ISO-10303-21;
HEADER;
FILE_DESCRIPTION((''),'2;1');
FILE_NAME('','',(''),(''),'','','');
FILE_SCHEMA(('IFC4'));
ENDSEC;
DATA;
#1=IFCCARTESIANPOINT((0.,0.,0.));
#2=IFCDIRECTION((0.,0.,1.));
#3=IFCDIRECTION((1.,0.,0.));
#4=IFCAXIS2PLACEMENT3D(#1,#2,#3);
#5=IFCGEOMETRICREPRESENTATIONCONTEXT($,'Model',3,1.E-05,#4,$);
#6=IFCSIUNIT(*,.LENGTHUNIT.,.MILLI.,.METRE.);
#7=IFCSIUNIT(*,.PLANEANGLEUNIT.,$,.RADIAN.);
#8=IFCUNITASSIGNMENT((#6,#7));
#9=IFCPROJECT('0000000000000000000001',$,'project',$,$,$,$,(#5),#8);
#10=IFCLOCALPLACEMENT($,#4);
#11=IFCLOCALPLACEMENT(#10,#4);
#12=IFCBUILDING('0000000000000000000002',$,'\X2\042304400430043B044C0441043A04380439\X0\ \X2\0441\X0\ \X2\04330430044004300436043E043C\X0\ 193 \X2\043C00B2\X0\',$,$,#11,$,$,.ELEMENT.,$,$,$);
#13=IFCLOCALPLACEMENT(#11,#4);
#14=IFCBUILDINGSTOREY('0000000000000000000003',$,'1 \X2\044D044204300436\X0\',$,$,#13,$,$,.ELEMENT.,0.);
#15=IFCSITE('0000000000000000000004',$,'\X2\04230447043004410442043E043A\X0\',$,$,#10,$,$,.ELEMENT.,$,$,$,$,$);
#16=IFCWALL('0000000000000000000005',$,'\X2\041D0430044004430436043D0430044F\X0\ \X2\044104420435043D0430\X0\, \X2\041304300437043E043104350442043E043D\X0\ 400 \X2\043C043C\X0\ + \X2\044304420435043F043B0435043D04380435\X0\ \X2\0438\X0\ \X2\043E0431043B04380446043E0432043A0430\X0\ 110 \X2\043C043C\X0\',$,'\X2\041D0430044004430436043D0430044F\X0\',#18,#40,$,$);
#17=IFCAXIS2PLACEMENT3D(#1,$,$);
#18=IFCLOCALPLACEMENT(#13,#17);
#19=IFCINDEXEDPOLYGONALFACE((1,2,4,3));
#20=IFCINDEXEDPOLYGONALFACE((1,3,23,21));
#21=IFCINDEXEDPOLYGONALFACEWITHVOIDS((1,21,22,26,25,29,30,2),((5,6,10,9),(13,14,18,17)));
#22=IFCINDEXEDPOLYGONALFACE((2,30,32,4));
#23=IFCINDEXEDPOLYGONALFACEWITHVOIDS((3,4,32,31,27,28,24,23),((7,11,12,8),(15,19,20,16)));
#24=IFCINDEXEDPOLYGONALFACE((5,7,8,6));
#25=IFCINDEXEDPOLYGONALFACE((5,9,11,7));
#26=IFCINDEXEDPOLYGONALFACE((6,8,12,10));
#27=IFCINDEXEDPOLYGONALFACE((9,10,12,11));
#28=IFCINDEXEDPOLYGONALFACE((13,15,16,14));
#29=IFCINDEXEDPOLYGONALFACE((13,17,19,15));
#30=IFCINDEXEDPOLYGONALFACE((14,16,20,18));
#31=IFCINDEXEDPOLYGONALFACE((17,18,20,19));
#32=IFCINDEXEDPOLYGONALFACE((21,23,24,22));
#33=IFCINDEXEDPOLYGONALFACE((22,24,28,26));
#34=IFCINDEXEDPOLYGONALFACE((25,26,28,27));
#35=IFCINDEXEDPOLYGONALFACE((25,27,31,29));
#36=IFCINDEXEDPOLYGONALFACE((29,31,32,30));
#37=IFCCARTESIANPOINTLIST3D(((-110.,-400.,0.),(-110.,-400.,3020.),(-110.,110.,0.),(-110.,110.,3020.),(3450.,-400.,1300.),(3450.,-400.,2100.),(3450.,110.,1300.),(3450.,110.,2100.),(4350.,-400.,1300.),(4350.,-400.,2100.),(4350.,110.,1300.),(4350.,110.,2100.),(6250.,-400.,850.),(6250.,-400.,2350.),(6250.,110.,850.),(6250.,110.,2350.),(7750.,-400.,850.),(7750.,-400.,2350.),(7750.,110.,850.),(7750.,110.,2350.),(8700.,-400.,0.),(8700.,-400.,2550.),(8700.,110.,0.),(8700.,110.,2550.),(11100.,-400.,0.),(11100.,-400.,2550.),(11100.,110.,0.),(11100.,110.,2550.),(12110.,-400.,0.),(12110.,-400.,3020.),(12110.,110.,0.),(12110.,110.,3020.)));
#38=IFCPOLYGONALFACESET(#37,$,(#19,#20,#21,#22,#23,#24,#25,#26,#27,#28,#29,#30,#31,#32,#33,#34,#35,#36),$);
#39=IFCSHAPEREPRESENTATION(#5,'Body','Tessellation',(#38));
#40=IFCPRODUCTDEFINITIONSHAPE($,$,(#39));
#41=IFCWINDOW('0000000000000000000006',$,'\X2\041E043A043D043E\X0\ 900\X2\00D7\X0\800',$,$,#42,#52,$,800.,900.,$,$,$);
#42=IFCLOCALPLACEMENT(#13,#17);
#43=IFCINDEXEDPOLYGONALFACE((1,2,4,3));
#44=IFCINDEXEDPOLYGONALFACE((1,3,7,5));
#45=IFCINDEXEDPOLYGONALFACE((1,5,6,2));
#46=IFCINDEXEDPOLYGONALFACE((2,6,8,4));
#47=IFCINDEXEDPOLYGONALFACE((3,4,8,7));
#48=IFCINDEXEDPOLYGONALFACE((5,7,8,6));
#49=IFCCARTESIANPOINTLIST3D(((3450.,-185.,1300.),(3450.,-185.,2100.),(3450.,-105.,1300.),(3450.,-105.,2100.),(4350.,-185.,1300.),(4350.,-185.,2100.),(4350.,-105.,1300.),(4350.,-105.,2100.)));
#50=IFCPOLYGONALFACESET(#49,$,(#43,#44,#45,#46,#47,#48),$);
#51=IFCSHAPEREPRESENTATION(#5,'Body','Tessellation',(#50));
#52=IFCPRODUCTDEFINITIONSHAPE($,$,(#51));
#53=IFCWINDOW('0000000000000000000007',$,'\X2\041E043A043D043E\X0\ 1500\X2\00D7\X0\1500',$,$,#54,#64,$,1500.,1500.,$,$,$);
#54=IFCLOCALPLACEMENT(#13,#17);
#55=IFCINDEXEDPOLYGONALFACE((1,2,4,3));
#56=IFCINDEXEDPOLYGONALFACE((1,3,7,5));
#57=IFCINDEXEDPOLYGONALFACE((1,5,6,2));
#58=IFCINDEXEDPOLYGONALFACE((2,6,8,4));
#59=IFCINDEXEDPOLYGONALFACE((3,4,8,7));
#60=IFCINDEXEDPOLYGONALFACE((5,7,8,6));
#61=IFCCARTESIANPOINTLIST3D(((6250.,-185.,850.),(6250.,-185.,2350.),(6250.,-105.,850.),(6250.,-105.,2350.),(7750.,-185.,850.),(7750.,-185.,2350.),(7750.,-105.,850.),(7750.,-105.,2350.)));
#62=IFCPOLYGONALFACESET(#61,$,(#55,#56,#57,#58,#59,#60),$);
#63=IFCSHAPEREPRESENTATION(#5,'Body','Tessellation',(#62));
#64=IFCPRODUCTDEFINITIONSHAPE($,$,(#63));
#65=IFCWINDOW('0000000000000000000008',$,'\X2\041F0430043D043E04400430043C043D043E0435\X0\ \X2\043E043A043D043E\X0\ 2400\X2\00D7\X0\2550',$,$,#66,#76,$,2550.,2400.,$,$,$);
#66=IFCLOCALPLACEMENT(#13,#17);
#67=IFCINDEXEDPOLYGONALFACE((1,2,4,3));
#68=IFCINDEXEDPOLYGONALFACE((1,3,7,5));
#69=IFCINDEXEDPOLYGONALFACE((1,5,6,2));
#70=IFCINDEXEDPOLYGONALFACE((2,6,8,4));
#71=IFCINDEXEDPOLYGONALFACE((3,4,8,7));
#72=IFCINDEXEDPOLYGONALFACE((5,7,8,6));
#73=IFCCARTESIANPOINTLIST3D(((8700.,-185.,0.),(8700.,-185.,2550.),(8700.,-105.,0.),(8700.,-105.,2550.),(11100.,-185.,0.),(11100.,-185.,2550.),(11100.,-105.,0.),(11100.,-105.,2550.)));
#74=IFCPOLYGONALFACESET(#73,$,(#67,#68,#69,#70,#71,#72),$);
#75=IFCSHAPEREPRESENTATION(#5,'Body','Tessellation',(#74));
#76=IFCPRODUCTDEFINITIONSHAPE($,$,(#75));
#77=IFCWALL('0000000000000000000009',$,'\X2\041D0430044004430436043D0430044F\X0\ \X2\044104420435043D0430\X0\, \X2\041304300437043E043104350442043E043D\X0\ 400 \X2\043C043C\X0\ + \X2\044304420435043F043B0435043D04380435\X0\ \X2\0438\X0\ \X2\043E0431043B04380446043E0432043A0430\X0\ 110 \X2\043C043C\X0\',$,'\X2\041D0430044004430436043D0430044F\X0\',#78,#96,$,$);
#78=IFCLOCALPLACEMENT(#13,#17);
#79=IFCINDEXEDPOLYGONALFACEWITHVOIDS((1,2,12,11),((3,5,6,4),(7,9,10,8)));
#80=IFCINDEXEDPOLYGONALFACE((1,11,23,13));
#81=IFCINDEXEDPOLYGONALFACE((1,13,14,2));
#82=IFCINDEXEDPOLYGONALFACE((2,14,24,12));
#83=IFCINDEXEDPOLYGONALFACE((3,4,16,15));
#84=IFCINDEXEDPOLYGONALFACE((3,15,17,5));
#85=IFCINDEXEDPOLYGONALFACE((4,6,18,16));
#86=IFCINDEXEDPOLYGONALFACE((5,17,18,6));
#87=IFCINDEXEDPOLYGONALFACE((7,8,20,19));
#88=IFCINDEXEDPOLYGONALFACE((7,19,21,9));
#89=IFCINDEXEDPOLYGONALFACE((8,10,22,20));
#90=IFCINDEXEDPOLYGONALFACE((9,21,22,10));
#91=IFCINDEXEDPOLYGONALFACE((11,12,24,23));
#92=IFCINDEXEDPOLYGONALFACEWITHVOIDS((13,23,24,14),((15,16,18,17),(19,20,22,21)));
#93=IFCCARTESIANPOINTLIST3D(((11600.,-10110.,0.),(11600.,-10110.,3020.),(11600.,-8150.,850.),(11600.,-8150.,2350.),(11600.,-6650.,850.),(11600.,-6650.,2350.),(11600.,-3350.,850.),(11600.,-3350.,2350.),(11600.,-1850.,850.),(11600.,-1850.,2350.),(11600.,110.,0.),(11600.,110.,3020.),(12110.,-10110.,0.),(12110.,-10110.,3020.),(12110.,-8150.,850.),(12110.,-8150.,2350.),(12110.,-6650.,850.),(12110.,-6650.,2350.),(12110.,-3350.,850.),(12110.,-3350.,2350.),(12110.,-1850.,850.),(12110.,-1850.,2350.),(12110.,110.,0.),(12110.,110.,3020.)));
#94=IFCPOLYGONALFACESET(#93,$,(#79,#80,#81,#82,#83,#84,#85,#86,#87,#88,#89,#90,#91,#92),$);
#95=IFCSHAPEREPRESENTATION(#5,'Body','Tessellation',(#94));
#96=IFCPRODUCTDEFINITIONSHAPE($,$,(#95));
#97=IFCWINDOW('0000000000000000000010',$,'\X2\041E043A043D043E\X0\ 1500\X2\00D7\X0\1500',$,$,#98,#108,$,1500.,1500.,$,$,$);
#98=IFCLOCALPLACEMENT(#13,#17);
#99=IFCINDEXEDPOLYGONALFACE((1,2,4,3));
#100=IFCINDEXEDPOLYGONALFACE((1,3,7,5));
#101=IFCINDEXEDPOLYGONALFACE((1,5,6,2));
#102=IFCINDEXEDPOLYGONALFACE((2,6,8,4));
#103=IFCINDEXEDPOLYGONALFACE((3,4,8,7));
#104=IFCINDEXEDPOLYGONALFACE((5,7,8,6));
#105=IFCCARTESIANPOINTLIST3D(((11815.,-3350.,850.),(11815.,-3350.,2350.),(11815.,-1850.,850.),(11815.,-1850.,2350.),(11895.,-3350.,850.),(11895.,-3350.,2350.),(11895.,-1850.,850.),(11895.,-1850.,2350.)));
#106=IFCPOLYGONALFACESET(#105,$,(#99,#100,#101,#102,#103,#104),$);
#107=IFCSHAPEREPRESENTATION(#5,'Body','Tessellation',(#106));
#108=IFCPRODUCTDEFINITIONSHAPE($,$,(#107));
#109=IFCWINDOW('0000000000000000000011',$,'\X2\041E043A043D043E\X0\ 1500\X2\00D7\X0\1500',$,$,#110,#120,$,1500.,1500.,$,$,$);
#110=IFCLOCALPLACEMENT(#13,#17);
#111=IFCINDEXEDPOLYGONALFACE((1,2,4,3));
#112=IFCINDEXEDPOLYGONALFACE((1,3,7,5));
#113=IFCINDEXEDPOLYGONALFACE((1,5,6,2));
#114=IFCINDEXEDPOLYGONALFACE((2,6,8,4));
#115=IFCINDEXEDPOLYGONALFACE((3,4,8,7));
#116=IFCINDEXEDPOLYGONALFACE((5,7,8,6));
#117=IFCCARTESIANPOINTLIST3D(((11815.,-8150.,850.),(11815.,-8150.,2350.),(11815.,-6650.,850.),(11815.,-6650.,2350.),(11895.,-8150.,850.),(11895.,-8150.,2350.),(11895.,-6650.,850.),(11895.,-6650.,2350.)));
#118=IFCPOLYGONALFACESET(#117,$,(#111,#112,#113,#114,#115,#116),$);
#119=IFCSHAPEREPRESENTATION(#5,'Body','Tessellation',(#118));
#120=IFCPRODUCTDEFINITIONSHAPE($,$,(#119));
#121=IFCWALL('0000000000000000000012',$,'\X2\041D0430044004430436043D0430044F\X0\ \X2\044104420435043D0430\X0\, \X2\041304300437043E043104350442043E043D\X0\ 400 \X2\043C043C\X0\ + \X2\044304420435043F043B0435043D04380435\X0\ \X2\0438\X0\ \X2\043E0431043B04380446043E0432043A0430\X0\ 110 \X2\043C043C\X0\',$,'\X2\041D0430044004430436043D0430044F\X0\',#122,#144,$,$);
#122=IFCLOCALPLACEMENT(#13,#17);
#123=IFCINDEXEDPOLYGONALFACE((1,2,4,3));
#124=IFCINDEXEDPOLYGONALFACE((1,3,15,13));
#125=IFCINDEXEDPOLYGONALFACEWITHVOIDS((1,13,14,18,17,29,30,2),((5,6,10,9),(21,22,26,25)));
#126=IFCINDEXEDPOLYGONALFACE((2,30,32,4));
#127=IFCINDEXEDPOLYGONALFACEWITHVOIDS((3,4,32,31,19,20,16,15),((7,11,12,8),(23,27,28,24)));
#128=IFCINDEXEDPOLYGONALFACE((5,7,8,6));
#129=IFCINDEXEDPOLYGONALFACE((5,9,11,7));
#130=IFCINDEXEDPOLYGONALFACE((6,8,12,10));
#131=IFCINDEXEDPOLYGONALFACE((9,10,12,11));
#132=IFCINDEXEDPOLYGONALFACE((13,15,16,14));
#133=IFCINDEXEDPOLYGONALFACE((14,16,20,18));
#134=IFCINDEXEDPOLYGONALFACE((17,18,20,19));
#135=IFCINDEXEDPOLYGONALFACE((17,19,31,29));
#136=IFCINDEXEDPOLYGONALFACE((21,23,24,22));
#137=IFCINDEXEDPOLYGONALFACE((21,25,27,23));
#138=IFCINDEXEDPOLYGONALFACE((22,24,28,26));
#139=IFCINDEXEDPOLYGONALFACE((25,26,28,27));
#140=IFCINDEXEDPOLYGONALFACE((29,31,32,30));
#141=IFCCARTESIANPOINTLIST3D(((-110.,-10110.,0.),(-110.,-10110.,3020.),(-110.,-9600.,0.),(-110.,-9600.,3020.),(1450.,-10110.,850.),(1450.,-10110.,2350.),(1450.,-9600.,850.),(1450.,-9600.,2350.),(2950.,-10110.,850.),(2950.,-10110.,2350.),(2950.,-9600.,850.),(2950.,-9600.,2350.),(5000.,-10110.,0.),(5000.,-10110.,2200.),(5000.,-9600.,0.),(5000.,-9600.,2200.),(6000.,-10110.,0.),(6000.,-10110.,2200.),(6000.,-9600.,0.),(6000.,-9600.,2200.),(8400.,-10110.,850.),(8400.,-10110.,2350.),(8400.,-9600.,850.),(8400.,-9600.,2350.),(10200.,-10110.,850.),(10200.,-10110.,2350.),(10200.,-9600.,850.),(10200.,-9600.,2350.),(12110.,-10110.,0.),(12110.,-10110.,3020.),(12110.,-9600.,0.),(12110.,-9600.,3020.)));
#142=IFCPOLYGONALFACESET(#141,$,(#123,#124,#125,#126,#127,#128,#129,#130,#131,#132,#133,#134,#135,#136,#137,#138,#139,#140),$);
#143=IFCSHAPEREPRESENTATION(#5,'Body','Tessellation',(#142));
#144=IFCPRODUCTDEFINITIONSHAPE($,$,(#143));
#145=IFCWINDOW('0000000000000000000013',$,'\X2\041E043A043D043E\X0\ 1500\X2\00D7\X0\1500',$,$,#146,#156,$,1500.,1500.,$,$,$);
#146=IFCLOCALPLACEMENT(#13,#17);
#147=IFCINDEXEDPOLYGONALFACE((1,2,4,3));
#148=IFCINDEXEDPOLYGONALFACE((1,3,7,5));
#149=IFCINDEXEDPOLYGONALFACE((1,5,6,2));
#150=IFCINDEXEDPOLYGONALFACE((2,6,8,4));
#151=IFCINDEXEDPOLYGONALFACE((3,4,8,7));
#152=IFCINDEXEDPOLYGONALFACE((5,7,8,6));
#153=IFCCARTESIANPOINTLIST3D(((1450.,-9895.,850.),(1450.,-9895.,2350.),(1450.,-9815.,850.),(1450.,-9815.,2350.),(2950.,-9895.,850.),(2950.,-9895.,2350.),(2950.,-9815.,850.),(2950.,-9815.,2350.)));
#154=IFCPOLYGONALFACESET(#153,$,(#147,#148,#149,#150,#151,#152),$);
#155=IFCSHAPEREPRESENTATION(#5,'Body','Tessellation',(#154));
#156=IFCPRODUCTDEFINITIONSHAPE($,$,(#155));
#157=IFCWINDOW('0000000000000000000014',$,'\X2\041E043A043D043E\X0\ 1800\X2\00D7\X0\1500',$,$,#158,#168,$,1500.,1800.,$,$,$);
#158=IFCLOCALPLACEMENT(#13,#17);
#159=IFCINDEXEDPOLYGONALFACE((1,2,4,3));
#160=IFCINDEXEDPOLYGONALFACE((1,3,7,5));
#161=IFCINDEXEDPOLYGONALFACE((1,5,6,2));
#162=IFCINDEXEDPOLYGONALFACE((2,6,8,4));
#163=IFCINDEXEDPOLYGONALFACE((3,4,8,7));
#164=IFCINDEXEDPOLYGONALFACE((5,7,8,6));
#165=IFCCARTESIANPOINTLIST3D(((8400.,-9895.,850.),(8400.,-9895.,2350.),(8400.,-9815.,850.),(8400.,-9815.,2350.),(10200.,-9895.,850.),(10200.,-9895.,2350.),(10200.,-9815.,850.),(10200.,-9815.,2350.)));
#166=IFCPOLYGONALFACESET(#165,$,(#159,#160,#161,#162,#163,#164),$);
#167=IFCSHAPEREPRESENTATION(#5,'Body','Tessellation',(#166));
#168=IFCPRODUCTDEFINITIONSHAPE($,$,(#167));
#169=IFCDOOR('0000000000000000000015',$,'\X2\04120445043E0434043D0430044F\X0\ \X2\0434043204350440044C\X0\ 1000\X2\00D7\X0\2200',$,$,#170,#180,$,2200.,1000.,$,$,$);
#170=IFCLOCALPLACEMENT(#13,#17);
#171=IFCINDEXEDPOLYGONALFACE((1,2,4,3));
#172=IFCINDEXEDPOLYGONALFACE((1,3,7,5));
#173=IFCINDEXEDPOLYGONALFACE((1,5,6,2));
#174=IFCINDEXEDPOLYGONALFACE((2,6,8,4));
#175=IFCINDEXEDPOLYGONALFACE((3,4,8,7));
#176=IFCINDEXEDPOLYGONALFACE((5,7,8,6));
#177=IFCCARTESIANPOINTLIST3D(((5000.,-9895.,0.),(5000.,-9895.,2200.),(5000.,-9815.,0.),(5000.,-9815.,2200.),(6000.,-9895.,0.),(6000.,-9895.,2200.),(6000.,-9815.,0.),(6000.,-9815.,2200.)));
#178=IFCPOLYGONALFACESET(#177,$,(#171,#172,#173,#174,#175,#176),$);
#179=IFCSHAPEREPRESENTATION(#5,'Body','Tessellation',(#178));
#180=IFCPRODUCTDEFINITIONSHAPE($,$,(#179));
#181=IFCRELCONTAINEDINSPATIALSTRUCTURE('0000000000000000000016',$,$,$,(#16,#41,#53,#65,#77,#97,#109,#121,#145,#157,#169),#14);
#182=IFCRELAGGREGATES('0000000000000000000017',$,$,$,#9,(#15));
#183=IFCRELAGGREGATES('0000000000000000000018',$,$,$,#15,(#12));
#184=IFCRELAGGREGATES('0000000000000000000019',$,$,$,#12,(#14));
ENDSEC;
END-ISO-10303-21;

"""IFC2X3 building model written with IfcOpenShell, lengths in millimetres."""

from ifc_helpers import new_model, si_unit, frame, frame_2d, origin, origin_with_axes, place, context, project, spatial, rectangle, extrude, element, fill, save


model = new_model("IFC2X3")

# Units and contexts
model_context = context("Model", 3, precision=1e-05, world=origin_with_axes())
ifc_project = project(units=[si_unit("LENGTHUNIT", "METRE", prefix="MILLI"), si_unit("PLANEANGLEUNIT", "RADIAN")], contexts=[model_context])

# Site, building, storey
site_placement = place(None, origin_with_axes())
site = spatial("IfcSite", under=ifc_project, at=site_placement, Name="Участок", CompositionType="ELEMENT")
building_placement = place(site_placement, origin_with_axes())
building = spatial("IfcBuilding", under=site, at=building_placement, Name="Уральский с гаражом 193 м²", CompositionType="ELEMENT")
storey_placement = place(building_placement, origin_with_axes())
storey = spatial("IfcBuildingStorey", under=building, at=storey_placement, Name="1 этаж", CompositionType="ELEMENT", Elevation=0.0)

# Walls, openings, windows
wall_1_placement = place(storey_placement, origin_with_axes())
wall_1 = element("IfcWall", 1, at=wall_1_placement, inside=storey, Name="Наружная стена, Газобетон 400 мм + утепление и облицовка 110 мм", ObjectType="Наружная", context=model_context, shape_type="SweptSolid", body=[
    extrude(rectangle(XDim=12220.0, YDim=510.0, at=frame_2d((6000.0, -145.0))), origin(), (0.0, 0.0, 1.0), 3020.0),
])
opening_1_placement = place(storey_placement, origin_with_axes())
opening_1 = element("IfcOpeningElement", 2, at=opening_1_placement, cuts=wall_1, ObjectType="Opening", context=model_context, shape_type="SweptSolid", body=[
    extrude(rectangle(XDim=900.0, YDim=530.0, at=frame_2d((3900.0, -145.0))), frame((0.0, 0.0, 1300.0)), (0.0, 0.0, 1.0), 800.0),
])
opening_2_placement = place(storey_placement, origin_with_axes())
opening_2 = element("IfcOpeningElement", 3, at=opening_2_placement, cuts=wall_1, ObjectType="Opening", context=model_context, shape_type="SweptSolid", body=[
    extrude(rectangle(XDim=1500.0, YDim=530.0, at=frame_2d((7000.0, -145.0))), frame((0.0, 0.0, 850.0)), (0.0, 0.0, 1.0), 1500.0),
])
opening_3_placement = place(storey_placement, origin_with_axes())
opening_3 = element("IfcOpeningElement", 4, at=opening_3_placement, cuts=wall_1, ObjectType="Opening", context=model_context, shape_type="SweptSolid", body=[
    extrude(rectangle(XDim=2400.0, YDim=530.0, at=frame_2d((9900.0, -145.0))), origin(), (0.0, 0.0, 1.0), 2550.0),
])
window_1_placement = place(storey_placement, origin_with_axes())
window_1 = element("IfcWindow", 5, at=window_1_placement, inside=storey, Name="Окно 900×800", OverallHeight=800.0, OverallWidth=900.0, context=model_context, shape_type="SweptSolid", body=[
    extrude(rectangle(XDim=900.0, YDim=80.0, at=frame_2d((3900.0, -145.0))), frame((0.0, 0.0, 1300.0)), (0.0, 0.0, 1.0), 800.0),
])
fill(opening_1, window_1)
window_2_placement = place(storey_placement, origin_with_axes())
window_2 = element("IfcWindow", 6, at=window_2_placement, inside=storey, Name="Окно 1500×1500", OverallHeight=1500.0, OverallWidth=1500.0, context=model_context, shape_type="SweptSolid", body=[
    extrude(rectangle(XDim=1500.0, YDim=80.0, at=frame_2d((7000.0, -145.0))), frame((0.0, 0.0, 850.0)), (0.0, 0.0, 1.0), 1500.0),
])
fill(opening_2, window_2)
window_3_placement = place(storey_placement, origin_with_axes())
window_3 = element("IfcWindow", 7, at=window_3_placement, inside=storey, Name="Панорамное окно 2400×2550", OverallHeight=2550.0, OverallWidth=2400.0, context=model_context, shape_type="SweptSolid", body=[
    extrude(rectangle(XDim=2400.0, YDim=80.0, at=frame_2d((9900.0, -145.0))), origin(), (0.0, 0.0, 1.0), 2550.0),
])
fill(opening_3, window_3)
wall_2_placement = place(storey_placement, origin_with_axes())
wall_2 = element("IfcWall", 8, at=wall_2_placement, inside=storey, Name="Наружная стена, Газобетон 400 мм + утепление и облицовка 110 мм", ObjectType="Наружная", context=model_context, shape_type="SweptSolid", body=[
    extrude(rectangle(XDim=510.0, YDim=10220.0, at=frame_2d((11855.0, -5000.0))), origin(), (0.0, 0.0, 1.0), 3020.0),
])
opening_4_placement = place(storey_placement, origin_with_axes())
opening_4 = element("IfcOpeningElement", 9, at=opening_4_placement, cuts=wall_2, ObjectType="Opening", context=model_context, shape_type="SweptSolid", body=[
    extrude(rectangle(XDim=530.0, YDim=1500.0, at=frame_2d((11855.0, -2600.0))), frame((0.0, 0.0, 850.0)), (0.0, 0.0, 1.0), 1500.0),
])
opening_5_placement = place(storey_placement, origin_with_axes())
opening_5 = element("IfcOpeningElement", 10, at=opening_5_placement, cuts=wall_2, ObjectType="Opening", context=model_context, shape_type="SweptSolid", body=[
    extrude(rectangle(XDim=530.0, YDim=1500.0, at=frame_2d((11855.0, -7400.0))), frame((0.0, 0.0, 850.0)), (0.0, 0.0, 1.0), 1500.0),
])
window_4_placement = place(storey_placement, origin_with_axes())
window_4 = element("IfcWindow", 11, at=window_4_placement, inside=storey, Name="Окно 1500×1500", OverallHeight=1500.0, OverallWidth=1500.0, context=model_context, shape_type="SweptSolid", body=[
    extrude(rectangle(XDim=80.0, YDim=1500.0, at=frame_2d((11855.0, -2600.0))), frame((0.0, 0.0, 850.0)), (0.0, 0.0, 1.0), 1500.0),
])
fill(opening_4, window_4)
window_5_placement = place(storey_placement, origin_with_axes())
window_5 = element("IfcWindow", 12, at=window_5_placement, inside=storey, Name="Окно 1500×1500", OverallHeight=1500.0, OverallWidth=1500.0, context=model_context, shape_type="SweptSolid", body=[
    extrude(rectangle(XDim=80.0, YDim=1500.0, at=frame_2d((11855.0, -7400.0))), frame((0.0, 0.0, 850.0)), (0.0, 0.0, 1.0), 1500.0),
])
fill(opening_5, window_5)

# Wall, openings, windows, door
wall_3_placement = place(storey_placement, origin_with_axes())
wall_3 = element("IfcWall", 13, at=wall_3_placement, inside=storey, Name="Наружная стена, Газобетон 400 мм + утепление и облицовка 110 мм", ObjectType="Наружная", context=model_context, shape_type="SweptSolid", body=[
    extrude(rectangle(XDim=12220.0, YDim=510.0, at=frame_2d((6000.0, -9855.0))), origin(), (0.0, 0.0, 1.0), 3020.0),
])
opening_6_placement = place(storey_placement, origin_with_axes())
opening_6 = element("IfcOpeningElement", 14, at=opening_6_placement, cuts=wall_3, ObjectType="Opening", context=model_context, shape_type="SweptSolid", body=[
    extrude(rectangle(XDim=1500.0, YDim=530.0, at=frame_2d((2200.0, -9855.0))), frame((0.0, 0.0, 850.0)), (0.0, 0.0, 1.0), 1500.0),
])
opening_7_placement = place(storey_placement, origin_with_axes())
opening_7 = element("IfcOpeningElement", 15, at=opening_7_placement, cuts=wall_3, ObjectType="Opening", context=model_context, shape_type="SweptSolid", body=[
    extrude(rectangle(XDim=1800.0, YDim=530.0, at=frame_2d((9300.0, -9855.0))), frame((0.0, 0.0, 850.0)), (0.0, 0.0, 1.0), 1500.0),
])
opening_8_placement = place(storey_placement, origin_with_axes())
opening_8 = element("IfcOpeningElement", 16, at=opening_8_placement, cuts=wall_3, ObjectType="Opening", context=model_context, shape_type="SweptSolid", body=[
    extrude(rectangle(XDim=1000.0, YDim=530.0, at=frame_2d((5500.0, -9855.0))), origin(), (0.0, 0.0, 1.0), 2200.0),
])
window_6_placement = place(storey_placement, origin_with_axes())
window_6 = element("IfcWindow", 17, at=window_6_placement, inside=storey, Name="Окно 1500×1500", OverallHeight=1500.0, OverallWidth=1500.0, context=model_context, shape_type="SweptSolid", body=[
    extrude(rectangle(XDim=1500.0, YDim=80.0, at=frame_2d((2200.0, -9855.0))), frame((0.0, 0.0, 850.0)), (0.0, 0.0, 1.0), 1500.0),
])
fill(opening_6, window_6)
window_7_placement = place(storey_placement, origin_with_axes())
window_7 = element("IfcWindow", 18, at=window_7_placement, inside=storey, Name="Окно 1800×1500", OverallHeight=1500.0, OverallWidth=1800.0, context=model_context, shape_type="SweptSolid", body=[
    extrude(rectangle(XDim=1800.0, YDim=80.0, at=frame_2d((9300.0, -9855.0))), frame((0.0, 0.0, 850.0)), (0.0, 0.0, 1.0), 1500.0),
])
fill(opening_7, window_7)
door_1_placement = place(storey_placement, origin_with_axes())
door_1 = element("IfcDoor", 19, at=door_1_placement, inside=storey, Name="Входная дверь 1000×2200", OverallHeight=2200.0, OverallWidth=1000.0, context=model_context, shape_type="SweptSolid", body=[
    extrude(rectangle(XDim=1000.0, YDim=80.0, at=frame_2d((5500.0, -9855.0))), origin(), (0.0, 0.0, 1.0), 2200.0),
])
fill(opening_8, door_1)

save(model, "model.ifc")
